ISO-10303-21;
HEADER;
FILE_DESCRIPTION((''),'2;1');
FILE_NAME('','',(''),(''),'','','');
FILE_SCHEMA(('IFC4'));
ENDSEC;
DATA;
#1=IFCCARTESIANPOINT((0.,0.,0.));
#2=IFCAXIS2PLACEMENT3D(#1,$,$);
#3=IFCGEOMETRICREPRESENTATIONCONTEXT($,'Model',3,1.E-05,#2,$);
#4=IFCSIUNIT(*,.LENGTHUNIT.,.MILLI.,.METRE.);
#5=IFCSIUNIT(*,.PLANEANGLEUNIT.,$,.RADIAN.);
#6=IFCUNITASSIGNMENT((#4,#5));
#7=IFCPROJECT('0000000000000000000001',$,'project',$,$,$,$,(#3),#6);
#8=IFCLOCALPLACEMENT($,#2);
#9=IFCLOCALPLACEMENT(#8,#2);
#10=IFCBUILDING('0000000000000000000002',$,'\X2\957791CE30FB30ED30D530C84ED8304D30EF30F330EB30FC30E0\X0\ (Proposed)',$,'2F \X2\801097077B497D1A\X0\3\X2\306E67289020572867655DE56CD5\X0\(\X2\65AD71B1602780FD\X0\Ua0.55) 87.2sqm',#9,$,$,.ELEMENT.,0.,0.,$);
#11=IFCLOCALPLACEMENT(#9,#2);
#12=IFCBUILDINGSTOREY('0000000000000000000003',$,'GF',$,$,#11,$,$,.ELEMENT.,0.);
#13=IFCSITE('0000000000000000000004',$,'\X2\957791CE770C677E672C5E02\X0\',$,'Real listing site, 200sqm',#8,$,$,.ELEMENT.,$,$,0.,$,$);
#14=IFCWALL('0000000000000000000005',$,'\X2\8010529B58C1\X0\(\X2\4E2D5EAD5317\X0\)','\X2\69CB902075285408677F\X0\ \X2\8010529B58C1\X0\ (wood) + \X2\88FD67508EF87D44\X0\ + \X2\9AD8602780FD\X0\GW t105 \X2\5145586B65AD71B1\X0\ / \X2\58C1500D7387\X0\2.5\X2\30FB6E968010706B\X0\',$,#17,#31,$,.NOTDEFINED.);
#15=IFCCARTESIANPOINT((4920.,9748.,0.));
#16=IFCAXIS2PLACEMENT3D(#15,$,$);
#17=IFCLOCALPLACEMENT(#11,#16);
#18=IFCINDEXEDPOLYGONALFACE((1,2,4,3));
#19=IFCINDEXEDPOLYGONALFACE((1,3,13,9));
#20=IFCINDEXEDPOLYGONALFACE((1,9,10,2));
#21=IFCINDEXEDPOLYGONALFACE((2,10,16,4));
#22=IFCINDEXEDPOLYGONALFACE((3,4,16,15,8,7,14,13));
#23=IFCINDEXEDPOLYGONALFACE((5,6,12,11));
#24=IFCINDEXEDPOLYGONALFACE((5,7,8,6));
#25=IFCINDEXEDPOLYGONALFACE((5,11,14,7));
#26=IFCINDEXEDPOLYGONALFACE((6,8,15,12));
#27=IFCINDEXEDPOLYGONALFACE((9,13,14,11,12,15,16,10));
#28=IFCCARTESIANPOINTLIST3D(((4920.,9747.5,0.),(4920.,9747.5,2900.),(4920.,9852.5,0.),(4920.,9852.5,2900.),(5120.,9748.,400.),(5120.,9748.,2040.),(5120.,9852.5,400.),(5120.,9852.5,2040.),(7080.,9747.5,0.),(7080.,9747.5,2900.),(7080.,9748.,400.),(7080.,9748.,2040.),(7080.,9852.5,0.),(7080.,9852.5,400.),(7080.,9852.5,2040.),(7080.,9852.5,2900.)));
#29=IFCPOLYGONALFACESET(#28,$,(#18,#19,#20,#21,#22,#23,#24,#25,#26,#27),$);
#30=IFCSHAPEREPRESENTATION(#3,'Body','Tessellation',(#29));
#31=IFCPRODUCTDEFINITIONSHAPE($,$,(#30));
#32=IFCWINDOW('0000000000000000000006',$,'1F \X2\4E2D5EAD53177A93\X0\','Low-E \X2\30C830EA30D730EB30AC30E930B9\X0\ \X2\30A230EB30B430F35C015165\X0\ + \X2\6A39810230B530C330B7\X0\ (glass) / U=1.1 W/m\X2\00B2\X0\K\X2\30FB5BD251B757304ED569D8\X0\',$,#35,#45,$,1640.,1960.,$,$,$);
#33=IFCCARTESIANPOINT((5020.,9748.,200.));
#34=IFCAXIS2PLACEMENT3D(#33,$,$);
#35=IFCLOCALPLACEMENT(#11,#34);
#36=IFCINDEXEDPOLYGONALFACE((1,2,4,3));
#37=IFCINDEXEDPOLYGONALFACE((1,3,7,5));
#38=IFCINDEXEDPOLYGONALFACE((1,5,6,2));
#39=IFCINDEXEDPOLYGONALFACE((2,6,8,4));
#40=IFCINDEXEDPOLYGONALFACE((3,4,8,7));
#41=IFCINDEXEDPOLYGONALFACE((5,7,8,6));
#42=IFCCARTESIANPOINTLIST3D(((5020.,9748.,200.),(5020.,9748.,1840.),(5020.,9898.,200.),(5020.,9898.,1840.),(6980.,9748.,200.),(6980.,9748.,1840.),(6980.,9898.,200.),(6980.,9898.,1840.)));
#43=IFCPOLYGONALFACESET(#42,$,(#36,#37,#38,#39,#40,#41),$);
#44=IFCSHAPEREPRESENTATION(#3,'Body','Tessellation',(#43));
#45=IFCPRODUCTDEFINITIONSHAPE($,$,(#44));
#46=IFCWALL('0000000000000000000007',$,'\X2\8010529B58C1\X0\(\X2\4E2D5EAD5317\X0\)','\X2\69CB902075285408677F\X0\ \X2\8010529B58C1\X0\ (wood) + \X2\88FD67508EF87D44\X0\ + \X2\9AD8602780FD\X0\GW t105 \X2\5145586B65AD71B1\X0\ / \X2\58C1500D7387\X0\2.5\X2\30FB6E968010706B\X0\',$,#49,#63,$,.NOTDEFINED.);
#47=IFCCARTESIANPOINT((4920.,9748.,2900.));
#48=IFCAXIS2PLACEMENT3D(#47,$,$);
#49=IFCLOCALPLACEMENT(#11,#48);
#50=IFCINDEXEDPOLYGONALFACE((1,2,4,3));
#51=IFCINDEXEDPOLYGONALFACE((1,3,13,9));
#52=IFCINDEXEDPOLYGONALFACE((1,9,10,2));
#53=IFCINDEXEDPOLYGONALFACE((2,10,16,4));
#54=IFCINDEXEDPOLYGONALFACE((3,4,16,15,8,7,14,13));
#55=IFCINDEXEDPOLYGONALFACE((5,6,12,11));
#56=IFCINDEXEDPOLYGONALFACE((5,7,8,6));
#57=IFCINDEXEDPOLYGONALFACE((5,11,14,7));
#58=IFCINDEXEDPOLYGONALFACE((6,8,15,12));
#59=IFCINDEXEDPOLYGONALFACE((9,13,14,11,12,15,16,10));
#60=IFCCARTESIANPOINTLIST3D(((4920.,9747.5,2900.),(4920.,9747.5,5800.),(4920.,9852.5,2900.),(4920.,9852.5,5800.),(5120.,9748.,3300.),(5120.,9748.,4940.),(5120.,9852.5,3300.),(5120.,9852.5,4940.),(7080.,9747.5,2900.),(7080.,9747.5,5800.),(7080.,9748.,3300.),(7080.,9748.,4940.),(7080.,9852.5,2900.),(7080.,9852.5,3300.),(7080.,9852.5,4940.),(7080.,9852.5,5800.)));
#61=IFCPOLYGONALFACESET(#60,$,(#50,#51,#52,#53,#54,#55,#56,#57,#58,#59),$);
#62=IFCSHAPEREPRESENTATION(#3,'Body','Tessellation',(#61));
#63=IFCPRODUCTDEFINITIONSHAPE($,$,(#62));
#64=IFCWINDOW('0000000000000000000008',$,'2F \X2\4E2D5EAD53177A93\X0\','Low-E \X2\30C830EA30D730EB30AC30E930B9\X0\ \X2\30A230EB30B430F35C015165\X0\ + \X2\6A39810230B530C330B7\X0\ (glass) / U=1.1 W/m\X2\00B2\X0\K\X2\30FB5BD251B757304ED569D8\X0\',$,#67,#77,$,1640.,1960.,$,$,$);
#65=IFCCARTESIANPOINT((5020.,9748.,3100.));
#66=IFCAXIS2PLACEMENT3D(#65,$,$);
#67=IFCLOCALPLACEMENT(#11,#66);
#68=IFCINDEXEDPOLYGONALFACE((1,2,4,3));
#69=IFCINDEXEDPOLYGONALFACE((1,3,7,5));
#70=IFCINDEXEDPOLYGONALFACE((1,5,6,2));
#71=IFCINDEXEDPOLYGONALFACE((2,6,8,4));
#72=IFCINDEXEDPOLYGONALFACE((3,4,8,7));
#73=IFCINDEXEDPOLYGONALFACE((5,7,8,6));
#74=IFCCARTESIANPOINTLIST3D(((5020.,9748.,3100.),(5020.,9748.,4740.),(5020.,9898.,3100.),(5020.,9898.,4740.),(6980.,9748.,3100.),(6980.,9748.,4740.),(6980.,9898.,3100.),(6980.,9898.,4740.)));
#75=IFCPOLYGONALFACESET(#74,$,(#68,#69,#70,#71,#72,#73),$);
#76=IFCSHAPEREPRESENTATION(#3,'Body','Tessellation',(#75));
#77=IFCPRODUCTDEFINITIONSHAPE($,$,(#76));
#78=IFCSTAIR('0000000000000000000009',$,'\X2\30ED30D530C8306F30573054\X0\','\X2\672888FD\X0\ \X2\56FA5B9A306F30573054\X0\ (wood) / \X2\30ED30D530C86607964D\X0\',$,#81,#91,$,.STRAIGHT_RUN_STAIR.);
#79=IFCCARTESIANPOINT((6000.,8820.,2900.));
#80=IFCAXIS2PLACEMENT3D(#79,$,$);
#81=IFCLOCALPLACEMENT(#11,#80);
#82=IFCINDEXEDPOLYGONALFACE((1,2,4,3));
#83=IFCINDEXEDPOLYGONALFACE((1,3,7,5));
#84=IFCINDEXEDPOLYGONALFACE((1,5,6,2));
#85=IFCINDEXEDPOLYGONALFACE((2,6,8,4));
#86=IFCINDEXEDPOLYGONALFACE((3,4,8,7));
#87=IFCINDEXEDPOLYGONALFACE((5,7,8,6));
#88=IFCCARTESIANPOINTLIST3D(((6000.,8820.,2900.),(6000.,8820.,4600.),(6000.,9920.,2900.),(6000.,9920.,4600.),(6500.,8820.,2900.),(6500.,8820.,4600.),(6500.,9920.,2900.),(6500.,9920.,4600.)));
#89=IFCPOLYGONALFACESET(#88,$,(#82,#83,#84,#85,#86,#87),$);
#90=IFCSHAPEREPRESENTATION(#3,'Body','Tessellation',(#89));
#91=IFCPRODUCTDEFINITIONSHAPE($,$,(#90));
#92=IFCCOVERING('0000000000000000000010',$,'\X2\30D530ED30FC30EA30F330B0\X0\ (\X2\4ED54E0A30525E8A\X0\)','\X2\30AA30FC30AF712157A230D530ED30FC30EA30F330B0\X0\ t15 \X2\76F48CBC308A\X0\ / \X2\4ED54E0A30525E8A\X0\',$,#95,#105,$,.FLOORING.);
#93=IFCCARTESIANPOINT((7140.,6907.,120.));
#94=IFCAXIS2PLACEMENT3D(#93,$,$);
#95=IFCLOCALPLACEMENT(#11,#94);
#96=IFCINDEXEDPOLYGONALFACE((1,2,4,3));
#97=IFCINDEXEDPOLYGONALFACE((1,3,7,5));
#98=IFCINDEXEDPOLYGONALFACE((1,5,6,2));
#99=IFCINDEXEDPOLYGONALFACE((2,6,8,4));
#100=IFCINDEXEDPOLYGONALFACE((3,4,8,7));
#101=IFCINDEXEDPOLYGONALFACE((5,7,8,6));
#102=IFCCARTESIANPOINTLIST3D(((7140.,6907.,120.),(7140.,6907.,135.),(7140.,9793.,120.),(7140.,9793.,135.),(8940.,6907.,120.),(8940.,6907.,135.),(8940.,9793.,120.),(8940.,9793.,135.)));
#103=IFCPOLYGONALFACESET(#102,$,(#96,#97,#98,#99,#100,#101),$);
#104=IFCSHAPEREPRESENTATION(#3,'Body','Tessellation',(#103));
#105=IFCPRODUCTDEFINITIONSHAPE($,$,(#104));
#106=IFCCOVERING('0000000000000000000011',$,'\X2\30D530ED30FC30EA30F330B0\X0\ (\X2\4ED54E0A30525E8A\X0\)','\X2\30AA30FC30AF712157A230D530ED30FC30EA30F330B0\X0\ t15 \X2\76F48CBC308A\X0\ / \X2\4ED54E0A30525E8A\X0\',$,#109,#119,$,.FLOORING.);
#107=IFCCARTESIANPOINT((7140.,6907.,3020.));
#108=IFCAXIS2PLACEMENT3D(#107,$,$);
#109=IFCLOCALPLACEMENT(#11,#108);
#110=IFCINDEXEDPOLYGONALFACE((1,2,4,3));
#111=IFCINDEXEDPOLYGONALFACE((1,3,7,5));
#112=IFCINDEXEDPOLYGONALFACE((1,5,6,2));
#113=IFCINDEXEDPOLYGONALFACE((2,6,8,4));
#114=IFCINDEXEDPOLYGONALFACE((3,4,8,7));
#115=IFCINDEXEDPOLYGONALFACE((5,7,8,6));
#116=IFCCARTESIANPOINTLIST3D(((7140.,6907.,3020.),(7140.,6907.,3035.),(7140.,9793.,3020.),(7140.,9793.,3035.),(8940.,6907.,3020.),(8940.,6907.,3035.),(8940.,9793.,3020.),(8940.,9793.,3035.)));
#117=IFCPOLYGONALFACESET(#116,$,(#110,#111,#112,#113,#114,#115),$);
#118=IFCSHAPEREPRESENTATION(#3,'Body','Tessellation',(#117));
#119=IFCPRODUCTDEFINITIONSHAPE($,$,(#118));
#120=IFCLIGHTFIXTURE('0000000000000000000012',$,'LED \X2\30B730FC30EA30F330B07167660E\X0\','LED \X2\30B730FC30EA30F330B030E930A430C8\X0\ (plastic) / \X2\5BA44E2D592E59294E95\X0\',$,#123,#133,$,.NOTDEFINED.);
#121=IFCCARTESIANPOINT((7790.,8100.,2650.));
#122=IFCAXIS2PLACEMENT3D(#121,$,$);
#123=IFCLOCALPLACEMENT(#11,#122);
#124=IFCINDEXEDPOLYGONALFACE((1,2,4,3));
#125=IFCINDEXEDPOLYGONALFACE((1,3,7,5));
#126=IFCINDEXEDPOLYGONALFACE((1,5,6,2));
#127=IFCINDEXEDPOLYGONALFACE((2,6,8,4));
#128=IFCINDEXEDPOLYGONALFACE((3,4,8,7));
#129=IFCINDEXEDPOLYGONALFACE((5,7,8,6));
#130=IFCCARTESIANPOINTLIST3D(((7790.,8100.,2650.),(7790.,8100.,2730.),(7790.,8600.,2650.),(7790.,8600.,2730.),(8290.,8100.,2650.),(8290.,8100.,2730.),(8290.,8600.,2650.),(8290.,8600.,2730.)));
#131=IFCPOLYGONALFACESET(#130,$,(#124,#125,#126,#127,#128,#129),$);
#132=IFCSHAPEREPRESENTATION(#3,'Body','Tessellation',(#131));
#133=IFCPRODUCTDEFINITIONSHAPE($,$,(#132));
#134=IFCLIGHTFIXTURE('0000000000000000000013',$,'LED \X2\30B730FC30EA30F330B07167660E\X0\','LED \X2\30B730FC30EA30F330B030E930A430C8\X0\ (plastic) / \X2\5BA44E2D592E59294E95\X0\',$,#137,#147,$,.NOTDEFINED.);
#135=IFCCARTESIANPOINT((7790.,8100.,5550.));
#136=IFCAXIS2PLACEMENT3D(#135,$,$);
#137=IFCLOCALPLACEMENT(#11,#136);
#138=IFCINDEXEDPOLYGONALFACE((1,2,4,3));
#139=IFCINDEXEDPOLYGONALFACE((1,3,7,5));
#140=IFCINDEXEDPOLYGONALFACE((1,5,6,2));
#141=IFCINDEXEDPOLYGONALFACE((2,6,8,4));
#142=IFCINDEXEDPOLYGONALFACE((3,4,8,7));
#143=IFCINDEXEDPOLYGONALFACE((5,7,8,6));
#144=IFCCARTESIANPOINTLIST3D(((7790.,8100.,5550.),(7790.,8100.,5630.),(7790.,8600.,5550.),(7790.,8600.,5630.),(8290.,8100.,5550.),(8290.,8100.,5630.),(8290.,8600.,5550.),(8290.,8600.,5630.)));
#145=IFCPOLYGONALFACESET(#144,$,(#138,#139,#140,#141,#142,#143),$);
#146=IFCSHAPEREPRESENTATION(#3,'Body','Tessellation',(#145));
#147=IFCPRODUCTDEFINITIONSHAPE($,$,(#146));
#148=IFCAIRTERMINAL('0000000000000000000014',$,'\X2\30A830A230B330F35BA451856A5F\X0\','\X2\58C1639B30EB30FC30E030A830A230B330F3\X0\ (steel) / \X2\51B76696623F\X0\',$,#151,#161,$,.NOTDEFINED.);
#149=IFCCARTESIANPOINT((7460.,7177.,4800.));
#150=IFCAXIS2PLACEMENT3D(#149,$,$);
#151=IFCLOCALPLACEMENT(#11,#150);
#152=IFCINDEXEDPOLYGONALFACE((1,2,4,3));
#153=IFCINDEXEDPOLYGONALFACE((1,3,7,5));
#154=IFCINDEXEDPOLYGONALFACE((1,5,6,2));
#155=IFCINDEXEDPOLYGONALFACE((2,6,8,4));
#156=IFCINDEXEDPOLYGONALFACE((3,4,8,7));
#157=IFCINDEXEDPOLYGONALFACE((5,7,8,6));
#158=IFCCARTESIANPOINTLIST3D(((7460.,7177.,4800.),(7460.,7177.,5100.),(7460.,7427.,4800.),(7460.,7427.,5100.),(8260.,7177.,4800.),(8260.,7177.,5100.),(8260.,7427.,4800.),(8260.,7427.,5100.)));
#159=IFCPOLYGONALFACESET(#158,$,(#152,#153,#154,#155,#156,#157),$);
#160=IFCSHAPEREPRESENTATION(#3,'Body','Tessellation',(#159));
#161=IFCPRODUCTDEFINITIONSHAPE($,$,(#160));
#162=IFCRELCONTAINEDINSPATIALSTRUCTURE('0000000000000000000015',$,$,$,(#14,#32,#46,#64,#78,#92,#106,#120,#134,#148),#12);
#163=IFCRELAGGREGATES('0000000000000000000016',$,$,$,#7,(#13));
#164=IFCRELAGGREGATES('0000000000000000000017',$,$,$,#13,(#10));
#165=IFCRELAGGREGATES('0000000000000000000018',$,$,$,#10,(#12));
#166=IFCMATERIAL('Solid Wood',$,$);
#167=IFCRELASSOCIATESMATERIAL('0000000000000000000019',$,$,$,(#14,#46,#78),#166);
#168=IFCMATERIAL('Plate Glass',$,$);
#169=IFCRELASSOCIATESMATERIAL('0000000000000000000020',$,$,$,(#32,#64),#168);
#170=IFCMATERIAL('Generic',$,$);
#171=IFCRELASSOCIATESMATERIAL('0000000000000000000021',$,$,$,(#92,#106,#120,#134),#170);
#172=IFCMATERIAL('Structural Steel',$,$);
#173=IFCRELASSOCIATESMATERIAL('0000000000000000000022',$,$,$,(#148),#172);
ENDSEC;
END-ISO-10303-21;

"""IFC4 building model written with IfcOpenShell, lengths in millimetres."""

from ifc_helpers import new_model, si_unit, frame, frame_2d, origin, place, context, project, spatial, rectangle, extrude, material, element, fill, save


model = new_model("IFC4")

# Units and contexts
model_context = context("Model", 3, precision=1e-05, world=origin())
ifc_project = project(units=[si_unit("LENGTHUNIT", "METRE", prefix="MILLI"), si_unit("PLANEANGLEUNIT", "RADIAN")], contexts=[model_context])

# Site, building, storey
site_placement = place(None, origin())
site = spatial("IfcSite", under=ifc_project, at=site_placement, Name="長野県松本市", ObjectType="Real listing site, 200sqm", CompositionType="ELEMENT", RefElevation=0.0)
building_placement = place(site_placement, origin())
building = spatial("IfcBuilding", under=site, at=building_placement, Name="長野・ロフト付きワンルーム (Proposed)", ObjectType="2F 耐震等級3の木造在来工法(断熱性能Ua0.55) 87.2sqm", CompositionType="ELEMENT", ElevationOfRefHeight=0.0, ElevationOfTerrain=0.0)
storey_placement = place(building_placement, origin())
storey = spatial("IfcBuildingStorey", under=building, at=storey_placement, Name="GF", CompositionType="ELEMENT", Elevation=0.0)

# Shared definitions
ifc_material_1 = material(Name="Solid Wood")

# Walls, openings, windows
wall_1_placement = place(storey_placement, frame((4920.0, 9748.0, 0.0)))
wall_1 = element("IfcWall", 1, at=wall_1_placement, inside=storey, material=ifc_material_1, Name="耐力壁(中庭北)", Description="構造用合板 耐力壁 (wood) + 製材軸組 + 高性能GW t105 充填断熱 / 壁倍率2.5・準耐火", PredefinedType="NOTDEFINED", context=model_context, shape_type="SweptSolid", body=[
    extrude(rectangle(XDim=2160.0, YDim=105.0, at=frame_2d((1080.0, 52.0))), frame((4920.0, 9748.0, 0.0)), (0.0, 0.0, 1.0), 2900.0),
])
opening_1_placement = place(storey_placement, frame((5020.0, 9748.0, 200.0)))
opening_1 = element("IfcOpeningElement", 2, at=opening_1_placement, cuts=wall_1, PredefinedType="NOTDEFINED", context=model_context, shape_type="SweptSolid", body=[
    extrude(rectangle(XDim=1960.0, YDim=150.0, at=frame_2d((980.0, 75.0))), frame((5020.0, 9748.0, 200.0)), (0.0, 0.0, 1.0), 1640.0),
])
ifc_material_2 = material(Name="Plate Glass")
window_1_placement = place(storey_placement, frame((5020.0, 9748.0, 200.0)))
window_1 = element("IfcWindow", 3, at=window_1_placement, inside=storey, material=ifc_material_2, Name="1F 中庭北窓", Description="Low-E トリプルガラス アルゴン封入 + 樹脂サッシ (glass) / U=1.1 W/m²K・寒冷地仕様", OverallHeight=1640.0, OverallWidth=1960.0, context=model_context, shape_type="SweptSolid", body=[
    extrude(rectangle(XDim=1960.0, YDim=150.0, at=frame_2d((980.0, 75.0))), frame((5020.0, 9748.0, 200.0)), (0.0, 0.0, 1.0), 1640.0),
])
fill(opening_1, window_1)
wall_2_placement = place(storey_placement, frame((4920.0, 9748.0, 2900.0)))
wall_2 = element("IfcWall", 4, at=wall_2_placement, inside=storey, material=ifc_material_1, Name="耐力壁(中庭北)", Description="構造用合板 耐力壁 (wood) + 製材軸組 + 高性能GW t105 充填断熱 / 壁倍率2.5・準耐火", PredefinedType="NOTDEFINED", context=model_context, shape_type="SweptSolid", body=[
    extrude(rectangle(XDim=2160.0, YDim=105.0, at=frame_2d((1080.0, 52.0))), frame((4920.0, 9748.0, 2900.0)), (0.0, 0.0, 1.0), 2900.0),
])
opening_2_placement = place(storey_placement, frame((5020.0, 9748.0, 3100.0)))
opening_2 = element("IfcOpeningElement", 5, at=opening_2_placement, cuts=wall_2, PredefinedType="NOTDEFINED", context=model_context, shape_type="SweptSolid", body=[
    extrude(rectangle(XDim=1960.0, YDim=150.0, at=frame_2d((980.0, 75.0))), frame((5020.0, 9748.0, 3100.0)), (0.0, 0.0, 1.0), 1640.0),
])
window_2_placement = place(storey_placement, frame((5020.0, 9748.0, 3100.0)))
window_2 = element("IfcWindow", 6, at=window_2_placement, inside=storey, material=ifc_material_2, Name="2F 中庭北窓", Description="Low-E トリプルガラス アルゴン封入 + 樹脂サッシ (glass) / U=1.1 W/m²K・寒冷地仕様", OverallHeight=1640.0, OverallWidth=1960.0, context=model_context, shape_type="SweptSolid", body=[
    extrude(rectangle(XDim=1960.0, YDim=150.0, at=frame_2d((980.0, 75.0))), frame((5020.0, 9748.0, 3100.0)), (0.0, 0.0, 1.0), 1640.0),
])
fill(opening_2, window_2)

# Stair
stair_placement = place(storey_placement, frame((6000.0, 8820.0, 2900.0)))
element("IfcStair", 7, at=stair_placement, inside=storey, material=ifc_material_1, Name="ロフトはしご", Description="木製 固定はしご (wood) / ロフト昇降", PredefinedType="STRAIGHT_RUN_STAIR", context=model_context, shape_type="SweptSolid", body=[
    extrude(rectangle(XDim=500.0, YDim=1100.0, at=frame_2d((250.0, 550.0))), frame((6000.0, 8820.0, 2900.0)), (0.0, 0.0, 1.0), 1700.0),
])

# Coverings
ifc_material_3 = material(Name="Generic")
covering_1_placement = place(storey_placement, frame((7140.0, 6907.0, 120.0)))
element("IfcCovering", 8, at=covering_1_placement, inside=storey, material=ifc_material_3, Name="フローリング (仕上げ床)", Description="オーク無垢フローリング t15 直貼り / 仕上げ床", PredefinedType="FLOORING", context=model_context, shape_type="SweptSolid", body=[
    extrude(rectangle(XDim=1800.0, YDim=2886.0, at=frame_2d((900.0, 1443.0))), frame((7140.0, 6907.0, 120.0)), (0.0, 0.0, 1.0), 15.0),
])
covering_2_placement = place(storey_placement, frame((7140.0, 6907.0, 3020.0)))
element("IfcCovering", 9, at=covering_2_placement, inside=storey, material=ifc_material_3, Name="フローリング (仕上げ床)", Description="オーク無垢フローリング t15 直貼り / 仕上げ床", PredefinedType="FLOORING", context=model_context, shape_type="SweptSolid", body=[
    extrude(rectangle(XDim=1800.0, YDim=2886.0, at=frame_2d((900.0, 1443.0))), frame((7140.0, 6907.0, 3020.0)), (0.0, 0.0, 1.0), 15.0),
])

# Light fixtures
light_fixture_1_placement = place(storey_placement, frame((7790.0, 8100.0, 2650.0)))
element("IfcLightFixture", 10, at=light_fixture_1_placement, inside=storey, material=ifc_material_3, Name="LED シーリング照明", Description="LED シーリングライト (plastic) / 室中央天井", PredefinedType="NOTDEFINED", context=model_context, shape_type="SweptSolid", body=[
    extrude(rectangle(XDim=500.0, YDim=500.0, at=frame_2d((250.0, 250.0))), frame((7790.0, 8100.0, 2650.0)), (0.0, 0.0, 1.0), 80.0),
])
light_fixture_2_placement = place(storey_placement, frame((7790.0, 8100.0, 5550.0)))
element("IfcLightFixture", 11, at=light_fixture_2_placement, inside=storey, material=ifc_material_3, Name="LED シーリング照明", Description="LED シーリングライト (plastic) / 室中央天井", PredefinedType="NOTDEFINED", context=model_context, shape_type="SweptSolid", body=[
    extrude(rectangle(XDim=500.0, YDim=500.0, at=frame_2d((250.0, 250.0))), frame((7790.0, 8100.0, 5550.0)), (0.0, 0.0, 1.0), 80.0),
])

# Air terminal
ifc_material_4 = material(Name="Structural Steel")
air_terminal_placement = place(storey_placement, frame((7460.0, 7177.0, 4800.0)))
element("IfcAirTerminal", 12, at=air_terminal_placement, inside=storey, material=ifc_material_4, Name="エアコン室内機", Description="壁掛ルームエアコン (steel) / 冷暖房", PredefinedType="NOTDEFINED", context=model_context, shape_type="SweptSolid", body=[
    extrude(rectangle(XDim=800.0, YDim=250.0, at=frame_2d((400.0, 125.0))), frame((7460.0, 7177.0, 4800.0)), (0.0, 0.0, 1.0), 300.0),
])

save(model, "model.ifc")
